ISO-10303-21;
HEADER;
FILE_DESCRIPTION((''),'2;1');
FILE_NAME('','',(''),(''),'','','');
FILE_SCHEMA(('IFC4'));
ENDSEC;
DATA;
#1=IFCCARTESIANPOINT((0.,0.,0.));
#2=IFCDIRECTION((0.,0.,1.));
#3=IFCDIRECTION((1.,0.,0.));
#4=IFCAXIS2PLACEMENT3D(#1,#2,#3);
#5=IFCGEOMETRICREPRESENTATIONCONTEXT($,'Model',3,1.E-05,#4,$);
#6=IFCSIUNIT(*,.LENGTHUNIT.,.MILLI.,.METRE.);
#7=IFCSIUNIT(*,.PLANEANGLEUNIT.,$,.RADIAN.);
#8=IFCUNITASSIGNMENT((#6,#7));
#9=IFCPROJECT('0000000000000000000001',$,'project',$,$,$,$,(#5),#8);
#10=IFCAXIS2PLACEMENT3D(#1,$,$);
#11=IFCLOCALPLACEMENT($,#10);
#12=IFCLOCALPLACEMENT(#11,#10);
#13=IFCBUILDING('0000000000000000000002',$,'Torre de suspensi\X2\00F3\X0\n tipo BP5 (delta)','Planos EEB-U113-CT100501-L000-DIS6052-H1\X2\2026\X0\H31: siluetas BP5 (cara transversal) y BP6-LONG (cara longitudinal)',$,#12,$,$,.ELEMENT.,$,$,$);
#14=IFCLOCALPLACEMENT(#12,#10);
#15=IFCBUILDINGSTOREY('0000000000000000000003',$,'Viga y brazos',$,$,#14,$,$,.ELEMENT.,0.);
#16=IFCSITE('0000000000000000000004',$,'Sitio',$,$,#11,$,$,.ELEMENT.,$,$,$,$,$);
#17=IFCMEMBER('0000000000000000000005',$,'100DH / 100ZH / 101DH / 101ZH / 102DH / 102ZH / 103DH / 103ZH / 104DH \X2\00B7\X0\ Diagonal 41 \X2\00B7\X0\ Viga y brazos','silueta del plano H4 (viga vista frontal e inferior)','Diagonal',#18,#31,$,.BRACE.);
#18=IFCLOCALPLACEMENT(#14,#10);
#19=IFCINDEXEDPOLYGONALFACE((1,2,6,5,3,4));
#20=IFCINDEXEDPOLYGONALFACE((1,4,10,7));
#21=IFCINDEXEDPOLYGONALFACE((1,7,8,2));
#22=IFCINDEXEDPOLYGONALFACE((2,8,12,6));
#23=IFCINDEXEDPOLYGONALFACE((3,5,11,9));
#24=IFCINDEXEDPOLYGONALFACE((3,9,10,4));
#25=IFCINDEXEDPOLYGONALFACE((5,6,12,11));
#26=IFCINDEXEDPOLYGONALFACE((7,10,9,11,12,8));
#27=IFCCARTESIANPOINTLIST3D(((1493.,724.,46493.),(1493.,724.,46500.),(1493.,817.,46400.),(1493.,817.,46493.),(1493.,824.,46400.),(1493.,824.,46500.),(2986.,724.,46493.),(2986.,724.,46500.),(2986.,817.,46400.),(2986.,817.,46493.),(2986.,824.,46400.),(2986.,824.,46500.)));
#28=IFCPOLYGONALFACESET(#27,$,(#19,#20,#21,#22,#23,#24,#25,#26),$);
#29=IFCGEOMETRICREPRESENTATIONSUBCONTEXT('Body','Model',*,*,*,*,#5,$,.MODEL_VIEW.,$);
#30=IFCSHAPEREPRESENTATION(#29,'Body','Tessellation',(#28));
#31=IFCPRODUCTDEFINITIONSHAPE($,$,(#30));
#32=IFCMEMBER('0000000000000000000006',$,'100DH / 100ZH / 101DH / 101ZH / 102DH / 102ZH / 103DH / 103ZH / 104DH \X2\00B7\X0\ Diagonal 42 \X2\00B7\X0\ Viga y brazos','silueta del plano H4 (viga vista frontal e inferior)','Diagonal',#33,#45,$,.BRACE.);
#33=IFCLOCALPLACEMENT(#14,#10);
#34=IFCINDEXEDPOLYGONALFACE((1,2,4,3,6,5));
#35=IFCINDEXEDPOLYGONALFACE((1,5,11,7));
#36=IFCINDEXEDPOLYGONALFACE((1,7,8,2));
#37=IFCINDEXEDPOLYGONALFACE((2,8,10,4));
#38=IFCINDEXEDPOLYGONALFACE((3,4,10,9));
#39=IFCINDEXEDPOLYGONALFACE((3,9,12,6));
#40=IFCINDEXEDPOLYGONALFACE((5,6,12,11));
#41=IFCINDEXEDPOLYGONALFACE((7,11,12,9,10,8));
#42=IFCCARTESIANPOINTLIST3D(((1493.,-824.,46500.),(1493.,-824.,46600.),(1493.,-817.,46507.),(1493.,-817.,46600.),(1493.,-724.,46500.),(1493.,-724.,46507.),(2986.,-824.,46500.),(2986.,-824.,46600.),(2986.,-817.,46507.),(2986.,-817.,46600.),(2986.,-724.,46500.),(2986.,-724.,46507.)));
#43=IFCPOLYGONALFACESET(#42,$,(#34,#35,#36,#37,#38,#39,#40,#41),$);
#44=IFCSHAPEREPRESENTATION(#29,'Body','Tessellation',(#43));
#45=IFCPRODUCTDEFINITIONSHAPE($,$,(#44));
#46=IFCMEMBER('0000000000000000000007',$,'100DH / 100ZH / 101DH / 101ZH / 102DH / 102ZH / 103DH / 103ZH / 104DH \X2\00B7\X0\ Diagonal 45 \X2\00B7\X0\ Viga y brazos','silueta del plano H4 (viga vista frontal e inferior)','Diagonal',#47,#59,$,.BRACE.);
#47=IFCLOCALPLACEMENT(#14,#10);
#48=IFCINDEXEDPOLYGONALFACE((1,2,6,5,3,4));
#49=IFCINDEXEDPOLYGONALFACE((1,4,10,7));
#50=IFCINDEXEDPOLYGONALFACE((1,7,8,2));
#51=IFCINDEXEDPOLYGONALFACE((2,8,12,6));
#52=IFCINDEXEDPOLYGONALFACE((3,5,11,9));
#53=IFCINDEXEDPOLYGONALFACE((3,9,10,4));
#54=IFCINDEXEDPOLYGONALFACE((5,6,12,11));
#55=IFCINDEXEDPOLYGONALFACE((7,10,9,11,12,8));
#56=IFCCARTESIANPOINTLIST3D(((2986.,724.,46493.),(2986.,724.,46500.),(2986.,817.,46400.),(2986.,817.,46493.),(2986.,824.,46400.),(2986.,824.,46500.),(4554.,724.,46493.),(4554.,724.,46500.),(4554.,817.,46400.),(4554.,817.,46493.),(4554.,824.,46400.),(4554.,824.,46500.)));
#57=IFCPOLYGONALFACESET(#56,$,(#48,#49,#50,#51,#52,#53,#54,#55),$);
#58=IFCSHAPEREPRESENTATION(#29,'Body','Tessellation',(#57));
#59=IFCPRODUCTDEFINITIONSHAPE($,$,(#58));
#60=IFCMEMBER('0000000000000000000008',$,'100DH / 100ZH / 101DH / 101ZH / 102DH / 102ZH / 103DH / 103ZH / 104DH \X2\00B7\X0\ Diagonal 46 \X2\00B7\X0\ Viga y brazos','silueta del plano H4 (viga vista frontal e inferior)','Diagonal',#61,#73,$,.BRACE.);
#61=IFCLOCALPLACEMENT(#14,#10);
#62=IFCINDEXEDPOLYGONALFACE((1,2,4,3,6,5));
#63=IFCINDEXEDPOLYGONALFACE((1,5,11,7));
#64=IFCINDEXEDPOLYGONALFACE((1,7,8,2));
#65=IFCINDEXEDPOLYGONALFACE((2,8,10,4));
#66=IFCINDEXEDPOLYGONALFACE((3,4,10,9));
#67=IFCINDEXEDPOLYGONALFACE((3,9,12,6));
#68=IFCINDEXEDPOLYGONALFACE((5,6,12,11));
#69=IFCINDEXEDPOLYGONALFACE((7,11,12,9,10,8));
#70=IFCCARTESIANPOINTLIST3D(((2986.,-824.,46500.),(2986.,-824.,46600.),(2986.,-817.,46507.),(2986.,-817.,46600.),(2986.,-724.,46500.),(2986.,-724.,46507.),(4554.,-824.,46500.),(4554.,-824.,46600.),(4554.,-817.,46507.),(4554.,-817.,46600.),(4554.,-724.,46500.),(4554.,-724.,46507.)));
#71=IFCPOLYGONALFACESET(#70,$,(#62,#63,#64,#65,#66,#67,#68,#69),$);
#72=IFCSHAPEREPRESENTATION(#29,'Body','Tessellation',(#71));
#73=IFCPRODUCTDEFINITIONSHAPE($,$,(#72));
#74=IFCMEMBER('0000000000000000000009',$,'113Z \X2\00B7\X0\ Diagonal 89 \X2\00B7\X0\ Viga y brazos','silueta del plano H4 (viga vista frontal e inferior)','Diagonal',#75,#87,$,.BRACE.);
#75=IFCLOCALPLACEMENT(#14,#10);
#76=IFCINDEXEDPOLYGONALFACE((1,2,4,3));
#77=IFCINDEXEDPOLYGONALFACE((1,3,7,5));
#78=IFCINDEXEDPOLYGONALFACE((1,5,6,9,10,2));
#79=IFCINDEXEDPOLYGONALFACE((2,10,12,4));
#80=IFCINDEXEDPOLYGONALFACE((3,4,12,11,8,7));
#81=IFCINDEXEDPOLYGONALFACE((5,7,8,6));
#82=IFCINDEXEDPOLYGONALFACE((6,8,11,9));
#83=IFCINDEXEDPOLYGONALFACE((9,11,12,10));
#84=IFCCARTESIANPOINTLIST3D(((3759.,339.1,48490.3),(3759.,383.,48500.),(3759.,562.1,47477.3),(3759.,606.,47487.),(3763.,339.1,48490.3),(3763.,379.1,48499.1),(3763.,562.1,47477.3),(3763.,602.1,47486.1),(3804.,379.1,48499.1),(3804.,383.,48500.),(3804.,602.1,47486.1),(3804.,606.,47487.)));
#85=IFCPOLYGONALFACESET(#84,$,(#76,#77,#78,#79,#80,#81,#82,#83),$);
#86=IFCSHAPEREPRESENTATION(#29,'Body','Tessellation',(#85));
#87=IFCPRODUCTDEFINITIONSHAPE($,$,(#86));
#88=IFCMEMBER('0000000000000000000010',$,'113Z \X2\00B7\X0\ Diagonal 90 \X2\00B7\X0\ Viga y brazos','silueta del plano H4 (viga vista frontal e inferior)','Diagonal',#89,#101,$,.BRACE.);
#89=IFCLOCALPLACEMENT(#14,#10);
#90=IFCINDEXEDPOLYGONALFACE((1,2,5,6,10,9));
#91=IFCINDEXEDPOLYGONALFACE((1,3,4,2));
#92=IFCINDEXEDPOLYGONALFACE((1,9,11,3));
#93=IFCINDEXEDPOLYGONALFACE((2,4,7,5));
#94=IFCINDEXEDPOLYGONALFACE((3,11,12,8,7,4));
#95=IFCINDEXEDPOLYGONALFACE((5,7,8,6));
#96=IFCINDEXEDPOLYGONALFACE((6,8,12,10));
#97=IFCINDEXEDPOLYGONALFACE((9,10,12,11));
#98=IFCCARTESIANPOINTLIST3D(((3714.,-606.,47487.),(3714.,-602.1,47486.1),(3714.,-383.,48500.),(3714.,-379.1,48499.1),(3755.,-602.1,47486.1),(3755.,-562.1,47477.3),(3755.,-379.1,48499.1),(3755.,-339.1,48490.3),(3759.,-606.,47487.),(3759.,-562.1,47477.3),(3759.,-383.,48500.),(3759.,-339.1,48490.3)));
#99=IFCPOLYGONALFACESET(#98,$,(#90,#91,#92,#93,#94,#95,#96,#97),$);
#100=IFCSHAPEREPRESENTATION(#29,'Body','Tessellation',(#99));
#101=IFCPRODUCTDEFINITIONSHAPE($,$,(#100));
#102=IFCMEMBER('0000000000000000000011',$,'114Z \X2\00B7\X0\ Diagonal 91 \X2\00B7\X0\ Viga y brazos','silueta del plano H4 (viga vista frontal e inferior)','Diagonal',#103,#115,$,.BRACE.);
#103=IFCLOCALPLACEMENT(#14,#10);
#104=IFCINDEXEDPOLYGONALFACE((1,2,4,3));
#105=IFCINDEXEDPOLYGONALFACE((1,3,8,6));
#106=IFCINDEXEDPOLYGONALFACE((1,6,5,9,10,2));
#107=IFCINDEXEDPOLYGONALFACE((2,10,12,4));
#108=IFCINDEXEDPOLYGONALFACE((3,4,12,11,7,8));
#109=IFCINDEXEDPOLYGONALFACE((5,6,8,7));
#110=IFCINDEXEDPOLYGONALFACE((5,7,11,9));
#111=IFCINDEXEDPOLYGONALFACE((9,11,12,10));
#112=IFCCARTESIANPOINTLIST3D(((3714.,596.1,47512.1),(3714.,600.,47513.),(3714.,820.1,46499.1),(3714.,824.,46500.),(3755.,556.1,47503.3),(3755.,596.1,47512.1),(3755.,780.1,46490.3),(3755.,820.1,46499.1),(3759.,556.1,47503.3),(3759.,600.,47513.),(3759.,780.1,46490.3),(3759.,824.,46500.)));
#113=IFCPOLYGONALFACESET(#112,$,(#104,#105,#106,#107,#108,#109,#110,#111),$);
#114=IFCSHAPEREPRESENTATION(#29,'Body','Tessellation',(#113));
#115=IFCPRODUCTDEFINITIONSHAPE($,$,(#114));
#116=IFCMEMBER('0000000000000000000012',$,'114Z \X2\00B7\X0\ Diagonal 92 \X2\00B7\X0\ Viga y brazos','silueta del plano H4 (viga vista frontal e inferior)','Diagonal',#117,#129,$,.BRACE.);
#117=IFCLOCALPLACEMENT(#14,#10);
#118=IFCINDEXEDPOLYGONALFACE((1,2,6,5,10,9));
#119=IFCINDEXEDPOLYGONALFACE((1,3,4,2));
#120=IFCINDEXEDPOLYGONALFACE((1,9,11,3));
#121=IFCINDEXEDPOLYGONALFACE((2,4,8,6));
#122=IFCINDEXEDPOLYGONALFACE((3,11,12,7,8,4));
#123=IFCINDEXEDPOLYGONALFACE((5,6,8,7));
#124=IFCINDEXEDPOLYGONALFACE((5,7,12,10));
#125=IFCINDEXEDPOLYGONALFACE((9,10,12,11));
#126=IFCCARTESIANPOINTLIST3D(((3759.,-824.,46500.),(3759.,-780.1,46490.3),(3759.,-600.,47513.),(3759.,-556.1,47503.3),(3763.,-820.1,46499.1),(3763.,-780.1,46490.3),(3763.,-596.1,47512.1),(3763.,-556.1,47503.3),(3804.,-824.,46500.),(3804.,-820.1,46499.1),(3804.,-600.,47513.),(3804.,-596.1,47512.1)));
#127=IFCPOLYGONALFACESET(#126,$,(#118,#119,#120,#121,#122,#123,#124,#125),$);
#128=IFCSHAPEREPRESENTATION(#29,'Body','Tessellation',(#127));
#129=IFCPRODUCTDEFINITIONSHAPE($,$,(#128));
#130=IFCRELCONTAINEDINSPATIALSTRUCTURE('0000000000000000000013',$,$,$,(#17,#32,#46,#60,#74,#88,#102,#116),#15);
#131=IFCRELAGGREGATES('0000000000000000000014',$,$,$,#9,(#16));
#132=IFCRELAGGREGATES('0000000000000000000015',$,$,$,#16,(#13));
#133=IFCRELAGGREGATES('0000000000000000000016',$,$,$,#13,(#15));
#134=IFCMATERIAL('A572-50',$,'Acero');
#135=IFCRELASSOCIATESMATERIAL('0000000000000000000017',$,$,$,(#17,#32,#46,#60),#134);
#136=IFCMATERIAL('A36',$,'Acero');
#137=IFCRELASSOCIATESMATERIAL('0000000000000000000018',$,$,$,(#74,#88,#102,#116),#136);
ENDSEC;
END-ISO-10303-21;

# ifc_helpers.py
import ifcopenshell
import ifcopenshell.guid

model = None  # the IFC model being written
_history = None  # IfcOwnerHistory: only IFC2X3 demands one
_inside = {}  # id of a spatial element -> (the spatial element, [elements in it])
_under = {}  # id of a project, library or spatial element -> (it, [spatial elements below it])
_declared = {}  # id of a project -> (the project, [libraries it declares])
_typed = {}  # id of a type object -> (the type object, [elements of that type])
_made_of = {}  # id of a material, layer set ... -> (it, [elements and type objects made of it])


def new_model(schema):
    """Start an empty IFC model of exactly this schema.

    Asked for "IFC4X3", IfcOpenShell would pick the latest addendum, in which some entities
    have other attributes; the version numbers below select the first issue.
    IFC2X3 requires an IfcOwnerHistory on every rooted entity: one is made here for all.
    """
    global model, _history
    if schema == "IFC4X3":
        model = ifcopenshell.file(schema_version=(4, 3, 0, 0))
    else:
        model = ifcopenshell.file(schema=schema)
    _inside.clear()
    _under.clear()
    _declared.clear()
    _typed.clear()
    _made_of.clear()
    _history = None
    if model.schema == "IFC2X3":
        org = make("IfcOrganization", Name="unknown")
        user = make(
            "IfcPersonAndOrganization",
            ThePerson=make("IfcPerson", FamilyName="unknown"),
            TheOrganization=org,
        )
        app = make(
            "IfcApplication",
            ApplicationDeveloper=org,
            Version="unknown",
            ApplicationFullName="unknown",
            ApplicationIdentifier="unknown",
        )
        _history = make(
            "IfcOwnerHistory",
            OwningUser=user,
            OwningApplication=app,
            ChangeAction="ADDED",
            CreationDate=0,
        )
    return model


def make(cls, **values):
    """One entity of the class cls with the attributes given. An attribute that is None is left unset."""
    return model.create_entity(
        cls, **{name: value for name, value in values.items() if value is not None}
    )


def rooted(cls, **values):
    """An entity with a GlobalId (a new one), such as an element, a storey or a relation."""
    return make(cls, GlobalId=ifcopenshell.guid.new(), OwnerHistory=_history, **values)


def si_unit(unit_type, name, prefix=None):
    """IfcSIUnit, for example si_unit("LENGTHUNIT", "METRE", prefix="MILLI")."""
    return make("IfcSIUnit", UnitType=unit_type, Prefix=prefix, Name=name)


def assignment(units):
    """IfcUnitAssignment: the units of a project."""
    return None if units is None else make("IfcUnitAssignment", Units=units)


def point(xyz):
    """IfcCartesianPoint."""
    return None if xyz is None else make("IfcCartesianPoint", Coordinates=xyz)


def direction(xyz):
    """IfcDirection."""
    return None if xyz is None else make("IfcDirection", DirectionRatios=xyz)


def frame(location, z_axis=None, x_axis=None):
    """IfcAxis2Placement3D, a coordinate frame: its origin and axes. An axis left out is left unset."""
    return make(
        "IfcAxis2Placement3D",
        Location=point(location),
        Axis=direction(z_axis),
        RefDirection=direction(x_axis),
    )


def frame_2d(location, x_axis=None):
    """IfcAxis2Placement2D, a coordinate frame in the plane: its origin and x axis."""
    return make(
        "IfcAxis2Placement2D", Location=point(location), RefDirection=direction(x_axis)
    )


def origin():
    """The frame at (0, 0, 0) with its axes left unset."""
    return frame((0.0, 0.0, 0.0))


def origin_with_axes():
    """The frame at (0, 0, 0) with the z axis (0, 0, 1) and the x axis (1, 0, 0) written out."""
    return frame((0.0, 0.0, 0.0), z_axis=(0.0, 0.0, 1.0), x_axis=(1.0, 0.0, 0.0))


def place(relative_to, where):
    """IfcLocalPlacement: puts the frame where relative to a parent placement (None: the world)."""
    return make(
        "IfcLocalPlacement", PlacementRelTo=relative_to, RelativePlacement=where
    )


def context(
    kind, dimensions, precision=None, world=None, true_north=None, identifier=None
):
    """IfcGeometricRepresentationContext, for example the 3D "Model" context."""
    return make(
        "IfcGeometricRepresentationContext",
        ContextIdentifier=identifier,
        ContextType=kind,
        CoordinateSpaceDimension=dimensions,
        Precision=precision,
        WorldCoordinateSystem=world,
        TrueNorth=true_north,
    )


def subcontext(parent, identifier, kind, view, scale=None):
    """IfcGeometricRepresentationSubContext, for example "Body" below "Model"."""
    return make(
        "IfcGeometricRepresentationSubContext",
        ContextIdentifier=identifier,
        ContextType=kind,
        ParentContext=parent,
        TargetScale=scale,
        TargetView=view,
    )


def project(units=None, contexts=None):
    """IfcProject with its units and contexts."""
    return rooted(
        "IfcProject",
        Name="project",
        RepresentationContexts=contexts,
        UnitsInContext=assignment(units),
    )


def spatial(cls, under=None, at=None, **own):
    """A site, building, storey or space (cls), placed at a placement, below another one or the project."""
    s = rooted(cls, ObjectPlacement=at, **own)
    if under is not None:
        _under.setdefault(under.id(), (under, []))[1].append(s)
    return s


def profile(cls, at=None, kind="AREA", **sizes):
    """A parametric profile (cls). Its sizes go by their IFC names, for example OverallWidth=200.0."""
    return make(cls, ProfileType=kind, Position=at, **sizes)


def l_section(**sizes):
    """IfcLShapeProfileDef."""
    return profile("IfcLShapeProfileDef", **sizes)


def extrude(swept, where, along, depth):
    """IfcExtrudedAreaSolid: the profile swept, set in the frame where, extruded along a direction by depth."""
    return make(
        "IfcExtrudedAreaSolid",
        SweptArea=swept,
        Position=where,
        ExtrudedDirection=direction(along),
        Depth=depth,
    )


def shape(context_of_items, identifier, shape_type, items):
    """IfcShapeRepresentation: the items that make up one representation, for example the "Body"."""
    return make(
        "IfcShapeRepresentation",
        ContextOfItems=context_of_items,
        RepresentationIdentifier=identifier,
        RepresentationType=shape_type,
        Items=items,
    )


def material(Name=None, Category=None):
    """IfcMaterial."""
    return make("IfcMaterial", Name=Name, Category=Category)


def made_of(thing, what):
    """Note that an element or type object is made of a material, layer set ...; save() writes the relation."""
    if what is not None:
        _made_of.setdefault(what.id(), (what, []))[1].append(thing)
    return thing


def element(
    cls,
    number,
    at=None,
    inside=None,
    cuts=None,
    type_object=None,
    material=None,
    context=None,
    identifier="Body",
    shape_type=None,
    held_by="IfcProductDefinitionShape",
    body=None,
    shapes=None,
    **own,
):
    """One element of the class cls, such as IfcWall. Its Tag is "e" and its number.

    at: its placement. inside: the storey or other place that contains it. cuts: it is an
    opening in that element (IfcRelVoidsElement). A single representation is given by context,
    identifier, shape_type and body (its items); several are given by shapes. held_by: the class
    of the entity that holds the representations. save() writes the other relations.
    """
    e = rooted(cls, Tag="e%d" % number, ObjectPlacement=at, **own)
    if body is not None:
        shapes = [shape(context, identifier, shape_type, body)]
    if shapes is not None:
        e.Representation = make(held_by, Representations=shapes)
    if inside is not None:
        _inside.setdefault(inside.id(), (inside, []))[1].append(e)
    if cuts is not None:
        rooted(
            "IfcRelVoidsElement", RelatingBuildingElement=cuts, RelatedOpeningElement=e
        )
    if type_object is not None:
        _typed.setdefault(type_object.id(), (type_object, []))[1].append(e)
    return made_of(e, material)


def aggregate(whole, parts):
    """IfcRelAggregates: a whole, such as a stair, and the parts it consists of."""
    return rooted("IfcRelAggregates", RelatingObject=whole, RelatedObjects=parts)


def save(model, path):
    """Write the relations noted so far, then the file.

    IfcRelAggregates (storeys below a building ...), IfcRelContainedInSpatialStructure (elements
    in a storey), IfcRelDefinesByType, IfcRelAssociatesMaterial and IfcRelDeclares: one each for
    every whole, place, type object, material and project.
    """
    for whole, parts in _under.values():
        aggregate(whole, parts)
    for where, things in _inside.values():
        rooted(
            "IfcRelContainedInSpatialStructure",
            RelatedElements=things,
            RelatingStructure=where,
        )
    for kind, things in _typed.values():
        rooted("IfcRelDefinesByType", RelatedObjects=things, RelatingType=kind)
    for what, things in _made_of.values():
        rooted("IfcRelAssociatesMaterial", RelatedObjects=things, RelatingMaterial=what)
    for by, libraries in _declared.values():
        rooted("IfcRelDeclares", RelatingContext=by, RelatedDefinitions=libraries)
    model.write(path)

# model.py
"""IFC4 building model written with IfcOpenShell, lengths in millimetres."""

from ifc_helpers import new_model, si_unit, frame, frame_2d, origin, origin_with_axes, place, context, subcontext, project, spatial, l_section, extrude, material, element, save


model = new_model("IFC4")

# Units and contexts
model_context = context("Model", 3, precision=1e-05, world=origin_with_axes())
body_context = subcontext(model_context, "Body", "Model", "MODEL_VIEW")
ifc_project = project(units=[si_unit("LENGTHUNIT", "METRE", prefix="MILLI"), si_unit("PLANEANGLEUNIT", "RADIAN")], contexts=[model_context])

# Site, building, storey
site_placement = place(None, origin())
site = spatial("IfcSite", under=ifc_project, at=site_placement, Name="Sitio", CompositionType="ELEMENT")
building_placement = place(site_placement, origin())
building = spatial("IfcBuilding", under=site, at=building_placement, Name="Torre de suspensión tipo BP5 (delta)", Description="Planos EEB-U113-CT100501-L000-DIS6052-H1…H31: siluetas BP5 (cara transversal) y BP6-LONG (cara longitudinal)", CompositionType="ELEMENT")
storey_placement = place(building_placement, origin())
storey = spatial("IfcBuildingStorey", under=building, at=storey_placement, Name="Viga y brazos", CompositionType="ELEMENT", Elevation=0.0)

# Members
ifc_material_1 = material(Name="A572-50", Category="Acero")
ifc_material_2 = material(Name="A36", Category="Acero")
for number, where, z_axis, x_axis, name in (
    (1, (1493.0, 824.0, 46500.0), (1.0, 0.0, 0.0), (0.0, -1.0, 0.0), "100DH / 100ZH / 101DH / 101ZH / 102DH / 102ZH / 103DH / 103ZH / 104DH · Diagonal 41 · Viga y brazos"),
    (2, (1493.0, -824.0, 46500.0), (1.0, 0.0, 0.0), (0.0, 1.0, 0.0), "100DH / 100ZH / 101DH / 101ZH / 102DH / 102ZH / 103DH / 103ZH / 104DH · Diagonal 42 · Viga y brazos"),
):
    element("IfcMember", number, at=place(storey_placement, frame(where, z_axis=z_axis, x_axis=x_axis)), inside=storey, material=ifc_material_1, Name=name, Description="silueta del plano H4 (viga vista frontal e inferior)", ObjectType="Diagonal", PredefinedType="BRACE", context=body_context, shape_type="SweptSolid", body=[
        extrude(l_section(Depth=100.0, Width=100.0, Thickness=7.0, at=frame_2d((50.0, 50.0))), None, (0.0, 0.0, 1.0), 1493.0),
    ])
for number, where, z_axis, x_axis, name in (
    (3, (2986.0, 824.0, 46500.0), (1.0, 0.0, 0.0), (0.0, -1.0, 0.0), "100DH / 100ZH / 101DH / 101ZH / 102DH / 102ZH / 103DH / 103ZH / 104DH · Diagonal 45 · Viga y brazos"),
    (4, (2986.0, -824.0, 46500.0), (1.0, 0.0, 0.0), (0.0, 1.0, 0.0), "100DH / 100ZH / 101DH / 101ZH / 102DH / 102ZH / 103DH / 103ZH / 104DH · Diagonal 46 · Viga y brazos"),
):
    element("IfcMember", number, at=place(storey_placement, frame(where, z_axis=z_axis, x_axis=x_axis)), inside=storey, material=ifc_material_1, Name=name, Description="silueta del plano H4 (viga vista frontal e inferior)", ObjectType="Diagonal", PredefinedType="BRACE", context=body_context, shape_type="SweptSolid", body=[
        extrude(l_section(Depth=100.0, Width=100.0, Thickness=7.0, at=frame_2d((50.0, 50.0))), None, (0.0, 0.0, 1.0), 1568.0),
    ])
for number, where, z_axis, x_axis, name in (
    (5, (3759.0, 606.0, 47487.0), (0.0, -0.214991, 0.976616), (0.0, -0.976616, -0.214991), "113Z · Diagonal 89 · Viga y brazos"),
    (6, (3759.0, -606.0, 47487.0), (0.0, 0.214991, 0.976616), (0.0, 0.976616, -0.214991), "113Z · Diagonal 90 · Viga y brazos"),
):
    element("IfcMember", number, at=place(storey_placement, frame(where, z_axis=z_axis, x_axis=x_axis)), inside=storey, material=ifc_material_2, Name=name, Description="silueta del plano H4 (viga vista frontal e inferior)", ObjectType="Diagonal", PredefinedType="BRACE", context=body_context, shape_type="SweptSolid", body=[
        extrude(l_section(Depth=45.0, Width=45.0, Thickness=4.0, at=frame_2d((22.5, 22.5))), None, (0.0, 0.0, 1.0), 1037.3),
    ])
for number, where, z_axis, x_axis, name in (
    (7, (3759.0, 600.0, 47513.0), (0.0, 0.21591, -0.976413), (0.0, -0.976413, -0.21591), "114Z · Diagonal 91 · Viga y brazos"),
    (8, (3759.0, -600.0, 47513.0), (0.0, -0.21591, -0.976413), (0.0, 0.976413, -0.21591), "114Z · Diagonal 92 · Viga y brazos"),
):
    element("IfcMember", number, at=place(storey_placement, frame(where, z_axis=z_axis, x_axis=x_axis)), inside=storey, material=ifc_material_2, Name=name, Description="silueta del plano H4 (viga vista frontal e inferior)", ObjectType="Diagonal", PredefinedType="BRACE", context=body_context, shape_type="SweptSolid", body=[
        extrude(l_section(Depth=45.0, Width=45.0, Thickness=4.0, at=frame_2d((22.5, 22.5))), None, (0.0, 0.0, 1.0), 1037.5),
    ])

save(model, "model.ifc")
